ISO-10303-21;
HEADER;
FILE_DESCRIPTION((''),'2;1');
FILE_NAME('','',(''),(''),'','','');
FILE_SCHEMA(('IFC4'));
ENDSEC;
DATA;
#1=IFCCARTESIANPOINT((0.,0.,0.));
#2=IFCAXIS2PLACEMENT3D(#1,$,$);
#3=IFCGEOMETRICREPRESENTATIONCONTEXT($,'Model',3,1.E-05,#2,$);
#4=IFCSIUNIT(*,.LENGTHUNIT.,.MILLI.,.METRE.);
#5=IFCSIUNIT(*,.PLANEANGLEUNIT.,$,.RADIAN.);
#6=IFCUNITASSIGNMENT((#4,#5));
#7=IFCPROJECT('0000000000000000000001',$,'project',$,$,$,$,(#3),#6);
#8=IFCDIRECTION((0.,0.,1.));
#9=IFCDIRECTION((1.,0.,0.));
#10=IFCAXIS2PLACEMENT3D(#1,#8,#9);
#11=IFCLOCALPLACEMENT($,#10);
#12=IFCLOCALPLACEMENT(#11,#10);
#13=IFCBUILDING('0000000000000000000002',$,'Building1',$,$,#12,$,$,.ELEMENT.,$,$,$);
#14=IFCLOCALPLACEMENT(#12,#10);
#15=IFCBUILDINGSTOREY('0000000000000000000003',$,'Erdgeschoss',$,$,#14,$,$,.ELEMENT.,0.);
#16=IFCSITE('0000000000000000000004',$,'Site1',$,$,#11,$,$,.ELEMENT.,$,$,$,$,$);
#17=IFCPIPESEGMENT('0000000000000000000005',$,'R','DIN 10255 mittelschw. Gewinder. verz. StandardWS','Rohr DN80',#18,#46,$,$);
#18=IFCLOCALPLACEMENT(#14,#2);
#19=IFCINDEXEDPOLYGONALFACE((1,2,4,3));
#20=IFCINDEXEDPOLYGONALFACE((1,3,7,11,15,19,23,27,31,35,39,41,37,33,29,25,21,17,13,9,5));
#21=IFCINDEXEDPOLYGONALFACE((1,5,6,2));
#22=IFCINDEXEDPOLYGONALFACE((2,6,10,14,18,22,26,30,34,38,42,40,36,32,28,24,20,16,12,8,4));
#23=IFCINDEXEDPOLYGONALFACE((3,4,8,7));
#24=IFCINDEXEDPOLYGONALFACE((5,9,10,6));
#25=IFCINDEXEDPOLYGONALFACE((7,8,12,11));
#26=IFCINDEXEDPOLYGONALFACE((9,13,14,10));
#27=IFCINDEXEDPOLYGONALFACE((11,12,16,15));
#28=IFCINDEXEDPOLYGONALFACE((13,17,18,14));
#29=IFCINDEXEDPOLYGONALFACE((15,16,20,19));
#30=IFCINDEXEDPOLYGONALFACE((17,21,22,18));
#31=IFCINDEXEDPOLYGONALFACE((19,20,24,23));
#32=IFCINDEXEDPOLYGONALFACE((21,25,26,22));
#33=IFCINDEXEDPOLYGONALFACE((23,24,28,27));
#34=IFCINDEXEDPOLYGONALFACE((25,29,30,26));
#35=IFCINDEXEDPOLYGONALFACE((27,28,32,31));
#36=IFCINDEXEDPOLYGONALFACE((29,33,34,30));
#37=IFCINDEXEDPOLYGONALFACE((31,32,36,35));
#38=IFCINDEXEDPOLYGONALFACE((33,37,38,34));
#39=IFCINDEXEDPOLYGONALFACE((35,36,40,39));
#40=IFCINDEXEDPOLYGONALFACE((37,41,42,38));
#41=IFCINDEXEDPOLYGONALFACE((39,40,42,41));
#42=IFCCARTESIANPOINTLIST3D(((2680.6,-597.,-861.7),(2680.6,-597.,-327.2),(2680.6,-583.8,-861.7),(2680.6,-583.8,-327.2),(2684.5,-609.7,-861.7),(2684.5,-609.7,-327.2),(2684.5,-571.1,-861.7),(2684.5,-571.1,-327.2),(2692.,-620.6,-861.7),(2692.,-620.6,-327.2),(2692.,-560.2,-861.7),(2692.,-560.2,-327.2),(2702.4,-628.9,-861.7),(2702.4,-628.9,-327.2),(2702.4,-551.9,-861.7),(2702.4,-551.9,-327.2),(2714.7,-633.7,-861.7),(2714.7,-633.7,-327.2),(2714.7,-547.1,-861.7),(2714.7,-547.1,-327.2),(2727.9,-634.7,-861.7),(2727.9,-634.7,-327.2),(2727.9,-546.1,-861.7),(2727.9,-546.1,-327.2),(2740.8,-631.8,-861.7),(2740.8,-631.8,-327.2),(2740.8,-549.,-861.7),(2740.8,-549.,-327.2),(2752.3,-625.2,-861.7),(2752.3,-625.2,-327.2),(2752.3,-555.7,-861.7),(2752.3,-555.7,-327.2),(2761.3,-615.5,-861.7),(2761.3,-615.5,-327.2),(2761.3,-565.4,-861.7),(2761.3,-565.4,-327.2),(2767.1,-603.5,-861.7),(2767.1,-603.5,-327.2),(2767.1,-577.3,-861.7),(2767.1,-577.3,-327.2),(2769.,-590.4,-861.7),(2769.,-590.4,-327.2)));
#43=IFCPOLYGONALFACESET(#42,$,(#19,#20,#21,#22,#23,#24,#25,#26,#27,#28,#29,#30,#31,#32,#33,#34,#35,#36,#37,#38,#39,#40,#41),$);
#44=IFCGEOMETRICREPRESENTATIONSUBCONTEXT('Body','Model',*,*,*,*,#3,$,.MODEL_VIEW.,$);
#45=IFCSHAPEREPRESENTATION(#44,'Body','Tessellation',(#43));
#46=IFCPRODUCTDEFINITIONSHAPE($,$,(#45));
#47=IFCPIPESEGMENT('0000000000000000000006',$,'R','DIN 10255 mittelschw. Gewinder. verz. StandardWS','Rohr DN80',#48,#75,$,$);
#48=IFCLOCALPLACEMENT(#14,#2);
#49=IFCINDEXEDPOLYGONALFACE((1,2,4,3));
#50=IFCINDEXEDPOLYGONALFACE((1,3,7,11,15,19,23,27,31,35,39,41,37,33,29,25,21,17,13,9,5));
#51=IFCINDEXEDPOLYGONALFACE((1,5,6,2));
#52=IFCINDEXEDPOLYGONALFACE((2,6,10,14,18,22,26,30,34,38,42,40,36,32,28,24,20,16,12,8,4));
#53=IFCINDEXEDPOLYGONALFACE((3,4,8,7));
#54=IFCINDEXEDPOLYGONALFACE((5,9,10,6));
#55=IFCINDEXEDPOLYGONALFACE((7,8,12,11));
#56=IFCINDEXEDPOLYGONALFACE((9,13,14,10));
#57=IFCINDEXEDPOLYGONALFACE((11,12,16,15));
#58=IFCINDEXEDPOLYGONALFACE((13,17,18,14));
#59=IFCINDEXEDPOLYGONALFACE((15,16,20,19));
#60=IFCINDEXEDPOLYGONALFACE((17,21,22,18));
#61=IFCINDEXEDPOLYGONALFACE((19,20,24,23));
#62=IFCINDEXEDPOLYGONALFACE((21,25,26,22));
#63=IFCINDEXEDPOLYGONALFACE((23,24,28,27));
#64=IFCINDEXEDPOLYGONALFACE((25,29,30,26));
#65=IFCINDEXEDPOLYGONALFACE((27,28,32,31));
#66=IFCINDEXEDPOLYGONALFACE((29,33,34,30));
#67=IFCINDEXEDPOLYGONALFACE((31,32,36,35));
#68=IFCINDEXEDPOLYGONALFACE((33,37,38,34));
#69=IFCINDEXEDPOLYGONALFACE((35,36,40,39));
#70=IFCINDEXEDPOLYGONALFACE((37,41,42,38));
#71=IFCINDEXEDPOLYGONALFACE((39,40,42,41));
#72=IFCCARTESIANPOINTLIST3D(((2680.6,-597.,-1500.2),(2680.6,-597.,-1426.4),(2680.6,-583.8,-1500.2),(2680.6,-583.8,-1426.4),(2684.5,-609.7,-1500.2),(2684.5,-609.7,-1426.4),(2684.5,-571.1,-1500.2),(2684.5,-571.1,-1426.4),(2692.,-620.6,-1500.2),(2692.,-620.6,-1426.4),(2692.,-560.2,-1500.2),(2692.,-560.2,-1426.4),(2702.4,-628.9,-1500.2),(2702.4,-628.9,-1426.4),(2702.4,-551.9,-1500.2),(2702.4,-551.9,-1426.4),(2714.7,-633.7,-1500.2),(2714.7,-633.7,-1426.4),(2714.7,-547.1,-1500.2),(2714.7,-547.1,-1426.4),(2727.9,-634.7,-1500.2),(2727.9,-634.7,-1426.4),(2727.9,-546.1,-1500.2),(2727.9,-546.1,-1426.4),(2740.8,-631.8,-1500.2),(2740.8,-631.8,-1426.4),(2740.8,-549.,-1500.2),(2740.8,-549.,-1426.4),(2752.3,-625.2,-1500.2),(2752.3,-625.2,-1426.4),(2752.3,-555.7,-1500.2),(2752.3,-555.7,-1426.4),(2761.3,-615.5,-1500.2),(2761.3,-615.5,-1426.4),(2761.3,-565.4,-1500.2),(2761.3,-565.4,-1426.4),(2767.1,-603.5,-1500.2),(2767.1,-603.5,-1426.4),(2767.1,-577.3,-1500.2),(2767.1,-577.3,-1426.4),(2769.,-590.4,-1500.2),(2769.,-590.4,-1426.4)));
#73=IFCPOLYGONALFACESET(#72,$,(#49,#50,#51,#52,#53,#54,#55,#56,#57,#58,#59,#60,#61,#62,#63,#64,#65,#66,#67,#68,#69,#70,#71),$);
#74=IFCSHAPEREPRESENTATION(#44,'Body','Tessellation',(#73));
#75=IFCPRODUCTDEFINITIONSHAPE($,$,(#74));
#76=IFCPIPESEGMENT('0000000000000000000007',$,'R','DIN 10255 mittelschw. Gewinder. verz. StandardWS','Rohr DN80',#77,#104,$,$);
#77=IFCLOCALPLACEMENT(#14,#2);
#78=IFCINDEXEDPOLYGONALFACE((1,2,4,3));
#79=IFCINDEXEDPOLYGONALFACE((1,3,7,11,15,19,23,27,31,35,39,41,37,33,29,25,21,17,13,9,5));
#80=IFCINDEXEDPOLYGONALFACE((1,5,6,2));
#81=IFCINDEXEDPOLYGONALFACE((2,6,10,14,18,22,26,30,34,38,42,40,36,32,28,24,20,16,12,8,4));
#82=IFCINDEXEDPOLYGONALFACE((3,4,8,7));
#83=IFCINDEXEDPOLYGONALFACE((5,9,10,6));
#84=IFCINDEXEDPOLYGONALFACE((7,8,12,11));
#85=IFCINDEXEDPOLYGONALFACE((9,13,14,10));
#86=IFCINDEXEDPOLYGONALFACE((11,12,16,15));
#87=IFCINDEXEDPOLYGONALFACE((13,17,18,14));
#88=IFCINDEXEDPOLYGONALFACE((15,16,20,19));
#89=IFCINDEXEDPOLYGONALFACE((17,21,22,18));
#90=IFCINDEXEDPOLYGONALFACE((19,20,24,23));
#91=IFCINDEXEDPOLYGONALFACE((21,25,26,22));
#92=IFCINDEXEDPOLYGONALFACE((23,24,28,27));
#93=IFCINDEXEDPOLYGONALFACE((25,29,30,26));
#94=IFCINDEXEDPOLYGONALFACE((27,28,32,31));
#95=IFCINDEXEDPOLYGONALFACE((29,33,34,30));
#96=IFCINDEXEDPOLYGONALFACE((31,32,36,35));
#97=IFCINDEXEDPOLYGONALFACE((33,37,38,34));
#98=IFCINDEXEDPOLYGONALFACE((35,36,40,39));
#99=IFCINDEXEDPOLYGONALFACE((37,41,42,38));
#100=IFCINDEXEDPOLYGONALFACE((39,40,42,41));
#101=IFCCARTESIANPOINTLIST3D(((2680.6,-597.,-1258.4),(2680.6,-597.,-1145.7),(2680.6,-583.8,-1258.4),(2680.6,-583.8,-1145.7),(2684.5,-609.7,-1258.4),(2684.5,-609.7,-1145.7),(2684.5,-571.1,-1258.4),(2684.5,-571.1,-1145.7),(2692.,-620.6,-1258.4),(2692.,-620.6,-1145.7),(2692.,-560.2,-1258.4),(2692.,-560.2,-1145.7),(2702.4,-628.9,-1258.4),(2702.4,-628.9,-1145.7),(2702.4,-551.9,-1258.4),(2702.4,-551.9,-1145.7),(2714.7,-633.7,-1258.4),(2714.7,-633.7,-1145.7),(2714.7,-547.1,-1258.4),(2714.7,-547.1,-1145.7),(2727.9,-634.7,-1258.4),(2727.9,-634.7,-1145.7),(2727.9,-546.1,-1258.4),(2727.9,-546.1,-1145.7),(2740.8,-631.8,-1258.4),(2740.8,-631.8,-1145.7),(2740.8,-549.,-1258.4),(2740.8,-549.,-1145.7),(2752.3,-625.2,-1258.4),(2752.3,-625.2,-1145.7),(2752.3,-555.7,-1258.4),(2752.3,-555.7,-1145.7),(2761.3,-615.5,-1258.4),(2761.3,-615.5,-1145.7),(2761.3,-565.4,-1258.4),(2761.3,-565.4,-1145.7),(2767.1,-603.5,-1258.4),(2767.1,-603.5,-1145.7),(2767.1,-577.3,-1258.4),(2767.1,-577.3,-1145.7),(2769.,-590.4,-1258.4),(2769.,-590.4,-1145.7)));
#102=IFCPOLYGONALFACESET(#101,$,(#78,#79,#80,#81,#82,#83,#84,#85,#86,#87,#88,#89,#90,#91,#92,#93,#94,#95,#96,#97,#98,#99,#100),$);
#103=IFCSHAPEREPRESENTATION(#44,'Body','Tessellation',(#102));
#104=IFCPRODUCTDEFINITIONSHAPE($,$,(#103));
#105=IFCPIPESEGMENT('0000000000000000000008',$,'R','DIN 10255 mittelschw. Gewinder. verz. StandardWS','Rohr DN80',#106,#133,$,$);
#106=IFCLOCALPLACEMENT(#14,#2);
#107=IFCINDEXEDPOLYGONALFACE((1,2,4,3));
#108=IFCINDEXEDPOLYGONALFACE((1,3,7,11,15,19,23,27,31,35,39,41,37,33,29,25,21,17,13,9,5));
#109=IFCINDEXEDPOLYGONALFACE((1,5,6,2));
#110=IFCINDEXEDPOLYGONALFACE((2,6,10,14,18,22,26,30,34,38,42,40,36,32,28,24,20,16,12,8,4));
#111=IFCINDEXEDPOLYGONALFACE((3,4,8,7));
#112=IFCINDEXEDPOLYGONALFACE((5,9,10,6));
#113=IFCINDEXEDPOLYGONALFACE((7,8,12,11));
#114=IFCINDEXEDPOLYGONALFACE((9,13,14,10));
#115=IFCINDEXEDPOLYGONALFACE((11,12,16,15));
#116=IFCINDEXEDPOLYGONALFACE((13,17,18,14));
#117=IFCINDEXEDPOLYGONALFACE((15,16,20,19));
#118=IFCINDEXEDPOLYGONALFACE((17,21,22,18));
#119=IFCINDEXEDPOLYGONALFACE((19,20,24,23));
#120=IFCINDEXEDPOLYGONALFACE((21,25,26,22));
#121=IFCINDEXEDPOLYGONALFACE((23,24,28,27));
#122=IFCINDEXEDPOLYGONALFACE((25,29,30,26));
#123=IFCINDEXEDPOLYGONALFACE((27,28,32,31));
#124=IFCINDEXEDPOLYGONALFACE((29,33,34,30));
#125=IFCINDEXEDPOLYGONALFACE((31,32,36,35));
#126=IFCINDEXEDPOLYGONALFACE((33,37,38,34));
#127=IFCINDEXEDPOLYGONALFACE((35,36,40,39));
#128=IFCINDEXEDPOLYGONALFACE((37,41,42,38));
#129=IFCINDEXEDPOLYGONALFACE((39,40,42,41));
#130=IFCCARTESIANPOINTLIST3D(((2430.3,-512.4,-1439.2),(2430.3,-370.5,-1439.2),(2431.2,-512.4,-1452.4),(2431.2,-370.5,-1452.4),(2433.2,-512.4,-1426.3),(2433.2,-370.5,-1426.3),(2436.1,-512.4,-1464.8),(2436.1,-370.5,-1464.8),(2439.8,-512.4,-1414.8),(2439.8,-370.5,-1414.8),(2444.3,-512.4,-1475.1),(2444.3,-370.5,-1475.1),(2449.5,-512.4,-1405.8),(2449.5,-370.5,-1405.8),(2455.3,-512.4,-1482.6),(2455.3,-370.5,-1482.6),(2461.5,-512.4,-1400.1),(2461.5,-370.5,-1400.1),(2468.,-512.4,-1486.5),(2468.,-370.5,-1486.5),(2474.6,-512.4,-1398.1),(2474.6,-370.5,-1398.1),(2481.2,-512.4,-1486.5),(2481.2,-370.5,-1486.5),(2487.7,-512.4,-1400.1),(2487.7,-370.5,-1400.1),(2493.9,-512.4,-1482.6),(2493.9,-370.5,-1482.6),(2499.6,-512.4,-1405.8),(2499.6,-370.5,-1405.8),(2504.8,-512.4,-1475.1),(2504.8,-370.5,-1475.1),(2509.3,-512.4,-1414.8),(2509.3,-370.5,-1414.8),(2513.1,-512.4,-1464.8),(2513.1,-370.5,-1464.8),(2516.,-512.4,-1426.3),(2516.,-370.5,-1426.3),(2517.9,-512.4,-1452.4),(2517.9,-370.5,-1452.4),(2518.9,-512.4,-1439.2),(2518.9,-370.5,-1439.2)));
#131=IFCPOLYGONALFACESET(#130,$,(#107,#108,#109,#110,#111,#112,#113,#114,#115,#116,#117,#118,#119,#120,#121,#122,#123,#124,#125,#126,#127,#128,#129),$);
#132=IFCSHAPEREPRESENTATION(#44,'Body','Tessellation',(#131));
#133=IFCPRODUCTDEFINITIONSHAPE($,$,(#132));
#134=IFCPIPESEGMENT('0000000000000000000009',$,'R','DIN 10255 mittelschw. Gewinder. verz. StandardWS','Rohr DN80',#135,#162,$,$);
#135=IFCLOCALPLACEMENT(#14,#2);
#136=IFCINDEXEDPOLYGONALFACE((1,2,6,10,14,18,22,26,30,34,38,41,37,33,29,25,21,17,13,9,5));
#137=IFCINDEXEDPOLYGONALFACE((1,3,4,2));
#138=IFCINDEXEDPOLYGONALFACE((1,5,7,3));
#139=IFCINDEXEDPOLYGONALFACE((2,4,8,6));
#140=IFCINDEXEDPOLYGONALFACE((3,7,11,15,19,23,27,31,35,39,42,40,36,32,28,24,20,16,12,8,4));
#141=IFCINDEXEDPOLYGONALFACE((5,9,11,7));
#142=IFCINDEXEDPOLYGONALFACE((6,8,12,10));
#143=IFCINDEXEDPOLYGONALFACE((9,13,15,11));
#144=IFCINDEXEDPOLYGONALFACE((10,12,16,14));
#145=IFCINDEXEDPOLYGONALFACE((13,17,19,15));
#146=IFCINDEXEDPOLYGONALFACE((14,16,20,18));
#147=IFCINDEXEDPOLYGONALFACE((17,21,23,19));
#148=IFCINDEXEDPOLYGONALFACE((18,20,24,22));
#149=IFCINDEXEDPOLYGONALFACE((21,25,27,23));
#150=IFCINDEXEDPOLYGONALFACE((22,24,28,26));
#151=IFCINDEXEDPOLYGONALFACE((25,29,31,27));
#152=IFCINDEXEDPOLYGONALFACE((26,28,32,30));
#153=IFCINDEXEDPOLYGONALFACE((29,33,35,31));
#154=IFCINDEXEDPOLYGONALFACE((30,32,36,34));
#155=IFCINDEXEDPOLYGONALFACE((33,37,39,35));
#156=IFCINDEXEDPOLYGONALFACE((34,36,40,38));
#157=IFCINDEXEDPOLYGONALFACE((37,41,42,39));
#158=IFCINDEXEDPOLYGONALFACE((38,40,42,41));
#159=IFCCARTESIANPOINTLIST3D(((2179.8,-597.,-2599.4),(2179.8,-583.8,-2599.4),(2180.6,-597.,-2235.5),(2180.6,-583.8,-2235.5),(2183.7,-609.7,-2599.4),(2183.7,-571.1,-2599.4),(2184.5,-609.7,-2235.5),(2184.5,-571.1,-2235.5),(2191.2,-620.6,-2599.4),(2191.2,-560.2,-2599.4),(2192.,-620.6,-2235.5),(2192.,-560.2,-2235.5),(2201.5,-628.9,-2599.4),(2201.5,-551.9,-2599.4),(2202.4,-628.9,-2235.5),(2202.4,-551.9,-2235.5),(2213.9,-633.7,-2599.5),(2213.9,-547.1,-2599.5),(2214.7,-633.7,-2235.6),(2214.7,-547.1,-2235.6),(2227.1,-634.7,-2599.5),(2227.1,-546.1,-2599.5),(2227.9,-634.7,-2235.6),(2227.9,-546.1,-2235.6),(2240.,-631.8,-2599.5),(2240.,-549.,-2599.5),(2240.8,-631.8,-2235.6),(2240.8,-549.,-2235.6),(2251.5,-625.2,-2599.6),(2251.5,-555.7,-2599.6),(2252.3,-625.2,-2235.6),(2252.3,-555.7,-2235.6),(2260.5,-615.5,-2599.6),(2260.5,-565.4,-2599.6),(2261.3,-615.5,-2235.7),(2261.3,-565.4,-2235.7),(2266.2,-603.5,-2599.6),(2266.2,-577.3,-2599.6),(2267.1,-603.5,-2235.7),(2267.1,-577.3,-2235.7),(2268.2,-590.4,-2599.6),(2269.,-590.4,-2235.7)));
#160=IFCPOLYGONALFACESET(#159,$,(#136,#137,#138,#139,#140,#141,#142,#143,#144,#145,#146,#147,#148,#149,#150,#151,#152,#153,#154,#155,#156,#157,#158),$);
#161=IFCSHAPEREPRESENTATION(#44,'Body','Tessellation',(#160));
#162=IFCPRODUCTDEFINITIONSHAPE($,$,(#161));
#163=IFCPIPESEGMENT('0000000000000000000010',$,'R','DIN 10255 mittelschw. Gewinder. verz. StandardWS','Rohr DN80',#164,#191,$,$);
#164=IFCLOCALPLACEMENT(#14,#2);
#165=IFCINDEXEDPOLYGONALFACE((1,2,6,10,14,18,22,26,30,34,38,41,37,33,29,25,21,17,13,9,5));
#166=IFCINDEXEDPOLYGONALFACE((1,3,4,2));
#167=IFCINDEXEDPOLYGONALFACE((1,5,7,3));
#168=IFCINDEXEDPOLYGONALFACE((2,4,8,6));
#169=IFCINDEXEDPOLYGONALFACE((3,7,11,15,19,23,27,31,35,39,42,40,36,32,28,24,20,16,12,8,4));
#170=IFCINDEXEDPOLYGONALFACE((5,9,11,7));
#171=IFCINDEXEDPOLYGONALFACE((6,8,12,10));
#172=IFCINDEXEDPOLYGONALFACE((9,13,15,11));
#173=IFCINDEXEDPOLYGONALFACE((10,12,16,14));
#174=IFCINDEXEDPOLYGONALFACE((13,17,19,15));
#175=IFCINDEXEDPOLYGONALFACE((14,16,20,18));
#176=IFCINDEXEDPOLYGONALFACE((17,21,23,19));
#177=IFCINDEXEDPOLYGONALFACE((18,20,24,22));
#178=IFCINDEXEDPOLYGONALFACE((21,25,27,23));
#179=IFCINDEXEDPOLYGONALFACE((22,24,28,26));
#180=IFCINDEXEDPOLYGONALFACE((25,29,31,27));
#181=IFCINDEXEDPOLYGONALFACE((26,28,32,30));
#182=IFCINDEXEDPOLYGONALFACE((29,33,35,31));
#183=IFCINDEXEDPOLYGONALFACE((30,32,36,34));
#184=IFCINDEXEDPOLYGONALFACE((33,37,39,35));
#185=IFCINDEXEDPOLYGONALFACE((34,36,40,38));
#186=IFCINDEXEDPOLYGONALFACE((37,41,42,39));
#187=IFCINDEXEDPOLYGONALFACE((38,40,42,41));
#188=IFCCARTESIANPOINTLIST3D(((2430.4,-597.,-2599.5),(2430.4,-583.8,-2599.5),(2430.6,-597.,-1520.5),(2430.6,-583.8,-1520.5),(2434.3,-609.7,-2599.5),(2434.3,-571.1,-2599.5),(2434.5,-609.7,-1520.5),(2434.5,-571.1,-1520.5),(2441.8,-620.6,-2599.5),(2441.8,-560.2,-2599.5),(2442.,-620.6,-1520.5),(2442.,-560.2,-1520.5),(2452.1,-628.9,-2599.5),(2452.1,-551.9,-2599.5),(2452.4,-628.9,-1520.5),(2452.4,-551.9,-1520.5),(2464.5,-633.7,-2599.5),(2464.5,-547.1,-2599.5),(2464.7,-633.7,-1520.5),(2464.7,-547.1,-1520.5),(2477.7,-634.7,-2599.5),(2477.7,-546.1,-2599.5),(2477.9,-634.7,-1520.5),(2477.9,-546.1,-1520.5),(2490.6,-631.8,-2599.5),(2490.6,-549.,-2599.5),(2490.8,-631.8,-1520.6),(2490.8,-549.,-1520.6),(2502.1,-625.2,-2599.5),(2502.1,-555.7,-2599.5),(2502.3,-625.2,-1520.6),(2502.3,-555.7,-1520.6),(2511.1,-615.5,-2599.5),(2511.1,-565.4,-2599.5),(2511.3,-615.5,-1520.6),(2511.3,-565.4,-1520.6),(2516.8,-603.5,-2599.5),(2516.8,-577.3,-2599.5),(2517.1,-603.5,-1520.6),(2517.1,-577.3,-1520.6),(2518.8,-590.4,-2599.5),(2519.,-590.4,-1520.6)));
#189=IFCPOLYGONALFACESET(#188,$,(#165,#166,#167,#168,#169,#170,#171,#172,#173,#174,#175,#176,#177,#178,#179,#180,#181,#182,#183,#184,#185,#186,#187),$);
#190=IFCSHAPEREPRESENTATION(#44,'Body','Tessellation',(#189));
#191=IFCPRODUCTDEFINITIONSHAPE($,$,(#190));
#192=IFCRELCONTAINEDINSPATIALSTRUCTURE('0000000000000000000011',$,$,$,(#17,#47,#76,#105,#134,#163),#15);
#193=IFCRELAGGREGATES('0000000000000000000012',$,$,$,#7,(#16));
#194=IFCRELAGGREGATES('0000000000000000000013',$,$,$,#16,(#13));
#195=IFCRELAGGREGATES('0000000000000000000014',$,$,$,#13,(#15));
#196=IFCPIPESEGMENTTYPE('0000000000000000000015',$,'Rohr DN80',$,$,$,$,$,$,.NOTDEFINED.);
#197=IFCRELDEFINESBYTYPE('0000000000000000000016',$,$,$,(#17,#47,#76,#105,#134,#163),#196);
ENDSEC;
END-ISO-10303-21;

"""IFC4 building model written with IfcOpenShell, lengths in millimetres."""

from ifc_helpers import new_model, si_unit, frame, origin, origin_with_axes, origin_2d_with_axis, place, context, subcontext, project, spatial, circle, extrude, type_object, element, save


model = new_model("IFC4")

# Units and contexts
model_context = context("Model", 3, precision=1e-05, world=origin())
body_context = subcontext(model_context, "Body", "Model", "MODEL_VIEW")
ifc_project = project(units=[si_unit("LENGTHUNIT", "METRE", prefix="MILLI"), si_unit("PLANEANGLEUNIT", "RADIAN")], contexts=[model_context])

# Site, building, storey
site_placement = place(None, origin_with_axes())
site = spatial("IfcSite", under=ifc_project, at=site_placement, Name="Site1", CompositionType="ELEMENT")
building_placement = place(site_placement, origin_with_axes())
building = spatial("IfcBuilding", under=site, at=building_placement, Name="Building1", CompositionType="ELEMENT")
storey_placement = place(building_placement, origin_with_axes())
storey = spatial("IfcBuildingStorey", under=building, at=storey_placement, Name="Erdgeschoss", CompositionType="ELEMENT", Elevation=0.0)

# Pipe segments
pipe_segment_type_1 = type_object("IfcPipeSegmentType", Name="Rohr DN80", PredefinedType="NOTDEFINED")
pipe_segment_1_placement = place(storey_placement, frame((2724.6, -590.6, -594.5), z_axis=(0.0, 0.0, 1.0), x_axis=(1.0, 0.0, 0.0)))
element("IfcPipeSegment", 1, at=pipe_segment_1_placement, inside=storey, type_object=pipe_segment_type_1, Name="R", Description="DIN 10255 mittelschw. Gewinder. verz. StandardWS", ObjectType="Rohr DN80", context=body_context, shape_type="SolidModel", body=[
    extrude(circle(Radius=44.5, at=origin_2d_with_axis()), frame((0.0, 0.1, -267.2), z_axis=(0.0, 0.0, 1.0), x_axis=(1.0, 0.0, 0.0)), (0.0, 0.0, 1.0), 534.5),
])
pipe_segment_2_placement = place(storey_placement, frame((2724.6, -590.6, -1463.3), z_axis=(0.0, 0.0, 1.0), x_axis=(1.0, 0.0, 0.0)))
element("IfcPipeSegment", 2, at=pipe_segment_2_placement, inside=storey, type_object=pipe_segment_type_1, Name="R", Description="DIN 10255 mittelschw. Gewinder. verz. StandardWS", ObjectType="Rohr DN80", context=body_context, shape_type="SolidModel", body=[
    extrude(circle(Radius=44.5, at=origin_2d_with_axis()), frame((0.0, 0.1, -36.9), z_axis=(0.0, 0.0, 1.0), x_axis=(1.0, 0.0, 0.0)), (0.0, 0.0, 1.0), 73.8),
])
pipe_segment_3_placement = place(storey_placement, frame((2724.6, -590.6, -1202.1), z_axis=(0.0, 0.0, 1.0), x_axis=(1.0, 0.0, 0.0)))
element("IfcPipeSegment", 3, at=pipe_segment_3_placement, inside=storey, type_object=pipe_segment_type_1, Name="R", Description="DIN 10255 mittelschw. Gewinder. verz. StandardWS", ObjectType="Rohr DN80", context=body_context, shape_type="SolidModel", body=[
    extrude(circle(Radius=44.5, at=origin_2d_with_axis()), frame((0.0, 0.1, -56.3), z_axis=(0.0, 0.0, 1.0), x_axis=(1.0, 0.0, 0.0)), (0.0, 0.0, 1.0), 112.7),
])
pipe_segment_4_placement = place(storey_placement, frame((2474.4, -441.5, -1442.5), z_axis=(0.0, 0.0, 1.0), x_axis=(1.0, 0.0, 0.0)))
element("IfcPipeSegment", 4, at=pipe_segment_4_placement, inside=storey, type_object=pipe_segment_type_1, Name="R", Description="DIN 10255 mittelschw. Gewinder. verz. StandardWS", ObjectType="Rohr DN80", context=body_context, shape_type="SolidModel", body=[
    extrude(circle(Radius=44.5, at=origin_2d_with_axis()), frame((0.2, -70.9, 0.0), z_axis=(0.0, 1.0, 0.0), x_axis=(0.0, 0.0, 1.0)), (0.0, 0.0, 1.0), 141.9),
])
pipe_segment_5_placement = place(storey_placement, frame((2224.2, -590.6, -2417.5), z_axis=(0.0, 0.0, 1.0), x_axis=(1.0, 0.0, 0.0)))
element("IfcPipeSegment", 5, at=pipe_segment_5_placement, inside=storey, type_object=pipe_segment_type_1, Name="R", Description="DIN 10255 mittelschw. Gewinder. verz. StandardWS", ObjectType="Rohr DN80", context=body_context, shape_type="SolidModel", body=[
    extrude(circle(Radius=44.5, at=origin_2d_with_axis()), frame((-0.4, 0.1, -182.0), z_axis=(0.002292, 0.0, 0.999997), x_axis=(1.0, 0.0, 0.0)), (0.0, 0.0, 1.0), 363.9),
])
pipe_segment_6_placement = place(storey_placement, frame((2474.5, -590.6, -2060.0), z_axis=(0.0, 0.0, 1.0), x_axis=(1.0, 0.0, 0.0)))
element("IfcPipeSegment", 6, at=pipe_segment_6_placement, inside=storey, type_object=pipe_segment_type_1, Name="R", Description="DIN 10255 mittelschw. Gewinder. verz. StandardWS", ObjectType="Rohr DN80", context=body_context, shape_type="SolidModel", body=[
    extrude(circle(Radius=44.5, at=origin_2d_with_axis()), frame((-0.1, 0.2, -539.5), z_axis=(0.000217, 0.0, 1.0), x_axis=(1.0, 0.0, 0.0)), (0.0, 0.0, 1.0), 1079.0),
])

save(model, "model.ifc")
